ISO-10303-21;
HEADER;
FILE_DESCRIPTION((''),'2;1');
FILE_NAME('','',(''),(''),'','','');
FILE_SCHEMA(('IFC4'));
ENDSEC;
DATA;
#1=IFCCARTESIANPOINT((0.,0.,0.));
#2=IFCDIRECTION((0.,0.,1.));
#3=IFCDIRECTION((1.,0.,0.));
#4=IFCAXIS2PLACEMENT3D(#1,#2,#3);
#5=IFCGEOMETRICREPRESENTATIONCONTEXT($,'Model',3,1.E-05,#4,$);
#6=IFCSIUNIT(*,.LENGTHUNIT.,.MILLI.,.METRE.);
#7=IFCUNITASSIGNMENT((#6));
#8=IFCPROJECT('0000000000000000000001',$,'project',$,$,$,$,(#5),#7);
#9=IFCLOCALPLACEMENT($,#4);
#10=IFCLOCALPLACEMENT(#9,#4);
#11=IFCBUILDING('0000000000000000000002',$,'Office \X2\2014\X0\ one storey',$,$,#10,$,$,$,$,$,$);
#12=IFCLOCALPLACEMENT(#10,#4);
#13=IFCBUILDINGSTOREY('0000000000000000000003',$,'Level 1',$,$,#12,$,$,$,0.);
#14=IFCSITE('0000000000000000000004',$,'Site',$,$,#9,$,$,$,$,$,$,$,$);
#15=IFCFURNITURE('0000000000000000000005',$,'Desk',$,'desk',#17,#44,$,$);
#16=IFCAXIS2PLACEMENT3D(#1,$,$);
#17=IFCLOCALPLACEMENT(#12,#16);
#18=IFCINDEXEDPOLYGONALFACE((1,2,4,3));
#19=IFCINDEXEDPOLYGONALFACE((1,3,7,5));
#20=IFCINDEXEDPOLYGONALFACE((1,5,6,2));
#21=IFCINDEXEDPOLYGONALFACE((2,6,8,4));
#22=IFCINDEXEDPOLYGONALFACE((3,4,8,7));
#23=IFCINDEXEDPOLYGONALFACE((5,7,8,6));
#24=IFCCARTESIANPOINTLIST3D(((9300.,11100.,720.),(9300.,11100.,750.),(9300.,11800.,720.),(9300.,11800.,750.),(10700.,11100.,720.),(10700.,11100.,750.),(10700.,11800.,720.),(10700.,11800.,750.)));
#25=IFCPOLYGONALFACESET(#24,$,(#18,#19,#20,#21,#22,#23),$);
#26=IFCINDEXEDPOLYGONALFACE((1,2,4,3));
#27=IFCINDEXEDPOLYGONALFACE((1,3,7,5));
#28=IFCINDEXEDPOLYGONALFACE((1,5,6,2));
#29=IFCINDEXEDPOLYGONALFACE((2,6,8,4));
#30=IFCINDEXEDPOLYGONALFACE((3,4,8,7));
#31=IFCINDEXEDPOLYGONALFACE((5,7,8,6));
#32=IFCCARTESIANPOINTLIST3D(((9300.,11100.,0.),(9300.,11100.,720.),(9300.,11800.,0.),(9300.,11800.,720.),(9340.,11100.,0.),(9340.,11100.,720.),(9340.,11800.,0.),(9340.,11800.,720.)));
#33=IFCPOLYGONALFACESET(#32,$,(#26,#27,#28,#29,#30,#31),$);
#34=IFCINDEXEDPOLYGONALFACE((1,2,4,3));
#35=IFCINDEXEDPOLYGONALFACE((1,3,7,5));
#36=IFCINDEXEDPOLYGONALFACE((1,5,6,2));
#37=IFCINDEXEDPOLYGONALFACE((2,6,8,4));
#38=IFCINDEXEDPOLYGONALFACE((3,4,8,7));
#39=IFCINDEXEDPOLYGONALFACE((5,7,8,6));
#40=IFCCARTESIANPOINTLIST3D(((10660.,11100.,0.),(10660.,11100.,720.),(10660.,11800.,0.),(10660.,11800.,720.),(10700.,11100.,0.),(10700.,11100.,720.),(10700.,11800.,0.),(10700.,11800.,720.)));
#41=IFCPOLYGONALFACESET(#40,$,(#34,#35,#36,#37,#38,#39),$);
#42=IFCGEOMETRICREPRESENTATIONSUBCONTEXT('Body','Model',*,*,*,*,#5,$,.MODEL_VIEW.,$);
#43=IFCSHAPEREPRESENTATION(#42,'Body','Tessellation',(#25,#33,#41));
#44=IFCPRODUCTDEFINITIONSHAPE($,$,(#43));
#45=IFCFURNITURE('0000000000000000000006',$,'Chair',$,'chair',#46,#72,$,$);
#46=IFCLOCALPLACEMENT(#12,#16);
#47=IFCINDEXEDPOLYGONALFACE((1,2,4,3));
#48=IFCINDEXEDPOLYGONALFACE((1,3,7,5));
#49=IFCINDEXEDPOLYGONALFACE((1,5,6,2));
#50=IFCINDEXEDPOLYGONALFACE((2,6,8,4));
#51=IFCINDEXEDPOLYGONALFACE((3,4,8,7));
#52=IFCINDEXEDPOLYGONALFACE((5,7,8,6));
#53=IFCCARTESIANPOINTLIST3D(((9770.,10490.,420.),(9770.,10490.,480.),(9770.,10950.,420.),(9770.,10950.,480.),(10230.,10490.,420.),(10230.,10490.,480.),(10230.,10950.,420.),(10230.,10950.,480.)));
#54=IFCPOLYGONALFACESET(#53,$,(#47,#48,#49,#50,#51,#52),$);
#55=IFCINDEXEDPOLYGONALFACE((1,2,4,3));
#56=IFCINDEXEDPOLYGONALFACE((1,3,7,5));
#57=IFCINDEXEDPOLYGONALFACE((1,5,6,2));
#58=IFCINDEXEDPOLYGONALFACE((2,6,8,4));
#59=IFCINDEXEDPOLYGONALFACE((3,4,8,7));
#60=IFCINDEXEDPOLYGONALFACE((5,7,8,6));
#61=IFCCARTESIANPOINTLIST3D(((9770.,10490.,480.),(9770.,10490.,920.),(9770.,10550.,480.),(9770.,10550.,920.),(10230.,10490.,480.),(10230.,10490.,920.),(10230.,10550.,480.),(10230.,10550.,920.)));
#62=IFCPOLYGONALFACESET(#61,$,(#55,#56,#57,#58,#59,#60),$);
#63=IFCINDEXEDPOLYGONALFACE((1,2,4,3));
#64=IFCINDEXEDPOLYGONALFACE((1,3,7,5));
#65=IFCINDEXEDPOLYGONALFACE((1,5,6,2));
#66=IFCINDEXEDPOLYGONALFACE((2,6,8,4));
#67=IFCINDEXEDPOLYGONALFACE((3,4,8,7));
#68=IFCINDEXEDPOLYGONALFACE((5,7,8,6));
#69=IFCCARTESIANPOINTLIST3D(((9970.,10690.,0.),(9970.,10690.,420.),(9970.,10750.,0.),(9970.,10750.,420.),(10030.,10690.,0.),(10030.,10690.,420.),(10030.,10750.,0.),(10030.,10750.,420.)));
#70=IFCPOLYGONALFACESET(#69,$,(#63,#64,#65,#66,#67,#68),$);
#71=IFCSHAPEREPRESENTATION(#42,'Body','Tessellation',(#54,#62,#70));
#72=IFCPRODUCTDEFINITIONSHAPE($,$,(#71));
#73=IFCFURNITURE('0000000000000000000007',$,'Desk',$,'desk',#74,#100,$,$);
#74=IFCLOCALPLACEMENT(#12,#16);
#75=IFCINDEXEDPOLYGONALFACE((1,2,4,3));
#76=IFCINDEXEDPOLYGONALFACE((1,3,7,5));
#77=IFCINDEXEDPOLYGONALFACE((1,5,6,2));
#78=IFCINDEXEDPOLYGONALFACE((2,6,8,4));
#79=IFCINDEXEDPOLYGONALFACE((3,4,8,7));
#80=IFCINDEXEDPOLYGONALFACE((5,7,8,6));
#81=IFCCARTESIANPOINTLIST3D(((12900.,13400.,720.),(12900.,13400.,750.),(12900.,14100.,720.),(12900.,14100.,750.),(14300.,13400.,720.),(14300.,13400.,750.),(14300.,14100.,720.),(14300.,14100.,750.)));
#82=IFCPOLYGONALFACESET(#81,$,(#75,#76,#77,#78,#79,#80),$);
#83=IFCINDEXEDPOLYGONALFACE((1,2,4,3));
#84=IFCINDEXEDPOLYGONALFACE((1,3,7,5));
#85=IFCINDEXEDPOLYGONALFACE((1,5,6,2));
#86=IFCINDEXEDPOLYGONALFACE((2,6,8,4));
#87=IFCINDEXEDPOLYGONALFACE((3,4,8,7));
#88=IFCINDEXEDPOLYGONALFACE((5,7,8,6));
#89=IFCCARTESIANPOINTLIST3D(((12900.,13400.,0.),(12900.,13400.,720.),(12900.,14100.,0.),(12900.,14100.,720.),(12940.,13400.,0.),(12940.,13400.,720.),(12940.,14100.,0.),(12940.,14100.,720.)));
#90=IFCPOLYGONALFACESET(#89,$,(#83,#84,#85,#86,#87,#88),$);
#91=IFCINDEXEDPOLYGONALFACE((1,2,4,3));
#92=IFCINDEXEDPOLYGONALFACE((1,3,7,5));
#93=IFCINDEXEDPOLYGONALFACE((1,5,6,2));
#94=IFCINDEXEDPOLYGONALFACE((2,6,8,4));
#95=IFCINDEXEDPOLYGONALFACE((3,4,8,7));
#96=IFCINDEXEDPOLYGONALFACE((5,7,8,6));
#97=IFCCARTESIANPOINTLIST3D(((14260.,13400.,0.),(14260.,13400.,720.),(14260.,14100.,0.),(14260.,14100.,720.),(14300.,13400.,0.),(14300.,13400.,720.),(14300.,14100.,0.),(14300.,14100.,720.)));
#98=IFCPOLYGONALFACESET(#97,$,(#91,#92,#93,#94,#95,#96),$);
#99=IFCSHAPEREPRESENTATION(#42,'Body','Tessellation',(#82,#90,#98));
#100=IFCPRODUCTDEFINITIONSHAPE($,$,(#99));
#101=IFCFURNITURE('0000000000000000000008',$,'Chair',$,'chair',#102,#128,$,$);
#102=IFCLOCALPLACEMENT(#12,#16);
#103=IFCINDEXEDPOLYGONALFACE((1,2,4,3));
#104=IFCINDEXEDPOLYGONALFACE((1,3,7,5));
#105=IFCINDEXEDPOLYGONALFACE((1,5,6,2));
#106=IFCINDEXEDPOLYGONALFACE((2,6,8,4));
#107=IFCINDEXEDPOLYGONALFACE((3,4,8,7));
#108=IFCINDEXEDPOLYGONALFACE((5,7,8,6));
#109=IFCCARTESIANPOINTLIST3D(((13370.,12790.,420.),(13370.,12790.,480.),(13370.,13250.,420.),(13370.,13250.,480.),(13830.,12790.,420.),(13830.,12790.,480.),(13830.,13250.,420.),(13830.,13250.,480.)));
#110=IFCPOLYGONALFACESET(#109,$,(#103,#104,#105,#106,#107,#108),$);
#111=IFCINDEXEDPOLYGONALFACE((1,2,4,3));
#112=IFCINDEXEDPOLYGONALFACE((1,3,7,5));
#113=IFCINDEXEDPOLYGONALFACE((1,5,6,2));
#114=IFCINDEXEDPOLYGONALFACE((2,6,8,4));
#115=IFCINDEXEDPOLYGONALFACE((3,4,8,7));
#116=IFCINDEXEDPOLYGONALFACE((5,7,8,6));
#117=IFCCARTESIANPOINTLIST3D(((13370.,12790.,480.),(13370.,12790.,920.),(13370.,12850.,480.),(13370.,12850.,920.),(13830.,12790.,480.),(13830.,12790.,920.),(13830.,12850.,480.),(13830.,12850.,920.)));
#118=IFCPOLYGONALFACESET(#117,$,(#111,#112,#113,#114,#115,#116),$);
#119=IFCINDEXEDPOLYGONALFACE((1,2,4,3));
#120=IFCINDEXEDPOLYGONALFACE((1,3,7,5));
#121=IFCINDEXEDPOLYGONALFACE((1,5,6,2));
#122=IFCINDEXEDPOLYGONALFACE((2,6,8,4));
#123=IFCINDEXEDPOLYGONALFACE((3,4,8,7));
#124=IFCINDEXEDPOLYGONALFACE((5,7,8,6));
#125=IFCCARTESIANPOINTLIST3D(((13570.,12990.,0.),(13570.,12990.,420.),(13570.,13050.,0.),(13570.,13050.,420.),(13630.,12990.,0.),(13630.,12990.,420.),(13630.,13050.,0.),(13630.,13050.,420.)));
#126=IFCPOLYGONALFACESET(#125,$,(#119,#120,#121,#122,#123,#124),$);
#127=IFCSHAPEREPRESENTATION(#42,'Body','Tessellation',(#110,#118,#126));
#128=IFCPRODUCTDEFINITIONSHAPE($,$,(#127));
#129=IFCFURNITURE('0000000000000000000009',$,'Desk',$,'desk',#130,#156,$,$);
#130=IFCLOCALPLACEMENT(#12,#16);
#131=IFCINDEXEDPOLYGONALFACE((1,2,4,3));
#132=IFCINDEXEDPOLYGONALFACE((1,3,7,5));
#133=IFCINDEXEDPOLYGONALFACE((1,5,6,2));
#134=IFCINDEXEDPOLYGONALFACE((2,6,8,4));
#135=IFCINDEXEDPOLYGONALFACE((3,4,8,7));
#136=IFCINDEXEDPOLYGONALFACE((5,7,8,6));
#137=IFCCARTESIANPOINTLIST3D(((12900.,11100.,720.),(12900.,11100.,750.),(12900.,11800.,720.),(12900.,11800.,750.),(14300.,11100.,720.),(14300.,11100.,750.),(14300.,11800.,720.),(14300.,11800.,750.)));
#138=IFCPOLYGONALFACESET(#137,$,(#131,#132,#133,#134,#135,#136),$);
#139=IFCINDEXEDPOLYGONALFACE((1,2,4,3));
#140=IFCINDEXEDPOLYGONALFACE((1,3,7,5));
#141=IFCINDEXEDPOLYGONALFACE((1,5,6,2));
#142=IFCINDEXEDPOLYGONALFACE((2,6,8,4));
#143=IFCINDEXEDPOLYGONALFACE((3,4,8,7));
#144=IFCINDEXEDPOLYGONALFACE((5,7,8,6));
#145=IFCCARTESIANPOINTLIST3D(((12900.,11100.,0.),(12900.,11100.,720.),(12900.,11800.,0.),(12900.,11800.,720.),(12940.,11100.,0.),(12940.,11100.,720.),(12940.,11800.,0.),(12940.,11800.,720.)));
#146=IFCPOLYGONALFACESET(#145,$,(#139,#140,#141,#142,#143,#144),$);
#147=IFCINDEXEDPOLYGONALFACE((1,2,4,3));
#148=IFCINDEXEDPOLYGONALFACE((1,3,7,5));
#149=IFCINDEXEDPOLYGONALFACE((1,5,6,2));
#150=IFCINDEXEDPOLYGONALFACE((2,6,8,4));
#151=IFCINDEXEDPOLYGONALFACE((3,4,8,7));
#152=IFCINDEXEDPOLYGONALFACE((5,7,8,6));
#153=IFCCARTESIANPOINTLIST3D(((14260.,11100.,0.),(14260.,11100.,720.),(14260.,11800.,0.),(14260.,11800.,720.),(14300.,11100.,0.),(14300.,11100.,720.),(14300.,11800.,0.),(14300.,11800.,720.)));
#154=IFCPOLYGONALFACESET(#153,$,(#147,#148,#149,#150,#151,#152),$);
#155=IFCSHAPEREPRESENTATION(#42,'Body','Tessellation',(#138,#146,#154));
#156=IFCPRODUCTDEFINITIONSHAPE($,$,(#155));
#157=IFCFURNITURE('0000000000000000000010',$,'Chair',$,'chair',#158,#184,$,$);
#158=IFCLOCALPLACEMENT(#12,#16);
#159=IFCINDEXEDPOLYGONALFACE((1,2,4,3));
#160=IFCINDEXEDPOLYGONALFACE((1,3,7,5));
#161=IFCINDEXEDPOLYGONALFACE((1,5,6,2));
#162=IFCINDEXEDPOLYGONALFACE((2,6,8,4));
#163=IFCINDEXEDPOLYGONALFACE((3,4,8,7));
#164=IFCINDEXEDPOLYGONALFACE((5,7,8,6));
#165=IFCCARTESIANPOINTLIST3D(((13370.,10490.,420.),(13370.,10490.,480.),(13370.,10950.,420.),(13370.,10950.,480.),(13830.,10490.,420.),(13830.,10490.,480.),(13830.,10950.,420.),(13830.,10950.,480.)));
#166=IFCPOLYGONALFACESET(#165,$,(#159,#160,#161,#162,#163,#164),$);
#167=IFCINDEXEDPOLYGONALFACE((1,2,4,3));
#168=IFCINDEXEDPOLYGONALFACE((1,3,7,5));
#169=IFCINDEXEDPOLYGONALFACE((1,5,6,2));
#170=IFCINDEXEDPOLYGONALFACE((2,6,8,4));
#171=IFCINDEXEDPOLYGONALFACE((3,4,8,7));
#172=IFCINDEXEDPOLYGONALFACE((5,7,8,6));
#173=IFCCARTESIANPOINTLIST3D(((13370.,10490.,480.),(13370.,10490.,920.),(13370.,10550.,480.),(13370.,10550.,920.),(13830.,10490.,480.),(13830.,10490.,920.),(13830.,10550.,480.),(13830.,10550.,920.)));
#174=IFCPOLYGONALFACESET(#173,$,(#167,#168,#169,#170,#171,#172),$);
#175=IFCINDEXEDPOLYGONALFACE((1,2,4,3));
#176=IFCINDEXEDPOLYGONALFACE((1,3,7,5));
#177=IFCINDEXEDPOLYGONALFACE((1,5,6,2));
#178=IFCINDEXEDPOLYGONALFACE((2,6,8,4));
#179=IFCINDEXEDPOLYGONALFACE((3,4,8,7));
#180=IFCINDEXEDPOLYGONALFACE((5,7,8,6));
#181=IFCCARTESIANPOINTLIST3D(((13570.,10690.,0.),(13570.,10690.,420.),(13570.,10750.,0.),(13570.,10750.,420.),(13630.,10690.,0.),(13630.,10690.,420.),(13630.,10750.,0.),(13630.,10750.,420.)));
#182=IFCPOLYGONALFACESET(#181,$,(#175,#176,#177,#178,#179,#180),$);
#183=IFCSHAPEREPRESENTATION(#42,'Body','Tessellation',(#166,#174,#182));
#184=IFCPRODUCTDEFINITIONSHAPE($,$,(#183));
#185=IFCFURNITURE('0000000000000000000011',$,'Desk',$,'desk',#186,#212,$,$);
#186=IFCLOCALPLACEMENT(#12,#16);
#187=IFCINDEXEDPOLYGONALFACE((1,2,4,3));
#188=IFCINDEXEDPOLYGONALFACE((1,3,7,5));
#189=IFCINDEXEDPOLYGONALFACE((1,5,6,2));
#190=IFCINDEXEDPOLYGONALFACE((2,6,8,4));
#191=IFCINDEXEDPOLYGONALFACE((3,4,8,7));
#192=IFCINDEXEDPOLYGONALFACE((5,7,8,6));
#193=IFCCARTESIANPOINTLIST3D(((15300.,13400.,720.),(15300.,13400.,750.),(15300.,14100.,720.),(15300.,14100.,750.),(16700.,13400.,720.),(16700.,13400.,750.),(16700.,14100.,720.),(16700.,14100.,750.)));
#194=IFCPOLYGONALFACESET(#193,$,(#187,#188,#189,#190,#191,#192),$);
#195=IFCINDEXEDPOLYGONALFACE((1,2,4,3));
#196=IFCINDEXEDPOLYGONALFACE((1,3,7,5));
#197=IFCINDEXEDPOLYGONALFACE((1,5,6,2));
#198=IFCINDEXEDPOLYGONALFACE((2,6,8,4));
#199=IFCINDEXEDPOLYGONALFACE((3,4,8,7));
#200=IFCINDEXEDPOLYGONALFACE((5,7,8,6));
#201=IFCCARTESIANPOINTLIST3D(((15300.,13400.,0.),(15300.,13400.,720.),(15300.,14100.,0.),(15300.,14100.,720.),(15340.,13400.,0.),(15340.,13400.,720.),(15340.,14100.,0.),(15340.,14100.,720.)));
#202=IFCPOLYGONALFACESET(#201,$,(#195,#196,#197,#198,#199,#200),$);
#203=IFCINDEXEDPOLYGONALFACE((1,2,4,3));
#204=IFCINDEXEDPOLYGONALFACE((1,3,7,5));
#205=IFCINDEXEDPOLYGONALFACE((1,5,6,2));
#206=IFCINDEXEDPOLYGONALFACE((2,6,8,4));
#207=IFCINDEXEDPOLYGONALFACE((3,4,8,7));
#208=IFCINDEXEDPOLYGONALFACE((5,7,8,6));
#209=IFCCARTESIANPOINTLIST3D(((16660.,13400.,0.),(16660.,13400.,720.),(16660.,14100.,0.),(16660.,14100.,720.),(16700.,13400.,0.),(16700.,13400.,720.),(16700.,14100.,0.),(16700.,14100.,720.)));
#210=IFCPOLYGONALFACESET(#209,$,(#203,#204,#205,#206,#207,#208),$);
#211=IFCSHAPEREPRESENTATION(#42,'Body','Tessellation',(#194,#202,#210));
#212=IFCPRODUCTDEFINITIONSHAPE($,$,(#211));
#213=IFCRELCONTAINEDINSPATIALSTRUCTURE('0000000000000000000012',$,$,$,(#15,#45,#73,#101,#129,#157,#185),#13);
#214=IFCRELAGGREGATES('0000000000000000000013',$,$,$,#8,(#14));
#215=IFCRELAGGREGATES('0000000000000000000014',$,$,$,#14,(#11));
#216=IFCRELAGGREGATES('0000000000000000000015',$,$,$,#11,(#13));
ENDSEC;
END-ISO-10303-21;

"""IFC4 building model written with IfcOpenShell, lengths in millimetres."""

from ifc_helpers import new_model, si_unit, frame, frame_2d, origin, origin_with_axes, place, context, subcontext, project, spatial, rectangle, extrude, element, save


model = new_model("IFC4")

# Units and contexts
model_context = context("Model", 3, precision=1e-05, world=origin_with_axes())
body_context = subcontext(model_context, "Body", "Model", "MODEL_VIEW")
ifc_project = project(units=[si_unit("LENGTHUNIT", "METRE", prefix="MILLI")], contexts=[model_context])

# Site, building, storey
site_placement = place(None, origin_with_axes())
site = spatial("IfcSite", under=ifc_project, at=site_placement, Name="Site")
building_placement = place(site_placement, origin_with_axes())
building = spatial("IfcBuilding", under=site, at=building_placement, Name="Office — one storey")
storey_placement = place(building_placement, origin_with_axes())
storey = spatial("IfcBuildingStorey", under=building, at=storey_placement, Name="Level 1", Elevation=0.0)

# Furniture
furniture_1_placement = place(storey_placement, frame((9300.0, 11100.0, 0.0), z_axis=(0.0, 0.0, 1.0), x_axis=(1.0, 0.0, 0.0)))
element("IfcFurniture", 1, at=furniture_1_placement, inside=storey, Name="Desk", ObjectType="desk", context=body_context, shape_type="SweptSolid", body=[
    extrude(rectangle(XDim=1400.0, YDim=700.0, at=frame_2d((700.0, 350.0))), frame((0.0, 0.0, 720.0)), (0.0, 0.0, 1.0), 30.0),
    extrude(rectangle(XDim=40.0, YDim=700.0, at=frame_2d((20.0, 350.0))), origin(), (0.0, 0.0, 1.0), 720.0),
    extrude(rectangle(XDim=40.0, YDim=700.0, at=frame_2d((1380.0, 350.0))), origin(), (0.0, 0.0, 1.0), 720.0),
])
furniture_2_placement = place(storey_placement, frame((9770.0, 10490.0, 0.0), z_axis=(0.0, 0.0, 1.0), x_axis=(1.0, 0.0, 0.0)))
element("IfcFurniture", 2, at=furniture_2_placement, inside=storey, Name="Chair", ObjectType="chair", context=body_context, shape_type="SweptSolid", body=[
    extrude(rectangle(XDim=460.0, YDim=460.0, at=frame_2d((230.0, 230.0))), frame((0.0, 0.0, 420.0)), (0.0, 0.0, 1.0), 60.0),
    extrude(rectangle(XDim=460.0, YDim=60.0, at=frame_2d((230.0, 30.0))), frame((0.0, 0.0, 480.0)), (0.0, 0.0, 1.0), 440.0),
    extrude(rectangle(XDim=60.0, YDim=60.0, at=frame_2d((230.0, 230.0))), origin(), (0.0, 0.0, 1.0), 420.0),
])
furniture_3_placement = place(storey_placement, frame((12900.0, 13400.0, 0.0), z_axis=(0.0, 0.0, 1.0), x_axis=(1.0, 0.0, 0.0)))
element("IfcFurniture", 3, at=furniture_3_placement, inside=storey, Name="Desk", ObjectType="desk", context=body_context, shape_type="SweptSolid", body=[
    extrude(rectangle(XDim=1400.0, YDim=700.0, at=frame_2d((700.0, 350.0))), frame((0.0, 0.0, 720.0)), (0.0, 0.0, 1.0), 30.0),
    extrude(rectangle(XDim=40.0, YDim=700.0, at=frame_2d((20.0, 350.0))), origin(), (0.0, 0.0, 1.0), 720.0),
    extrude(rectangle(XDim=40.0, YDim=700.0, at=frame_2d((1380.0, 350.0))), origin(), (0.0, 0.0, 1.0), 720.0),
])
furniture_4_placement = place(storey_placement, frame((13370.0, 12790.0, 0.0), z_axis=(0.0, 0.0, 1.0), x_axis=(1.0, 0.0, 0.0)))
element("IfcFurniture", 4, at=furniture_4_placement, inside=storey, Name="Chair", ObjectType="chair", context=body_context, shape_type="SweptSolid", body=[
    extrude(rectangle(XDim=460.0, YDim=460.0, at=frame_2d((230.0, 230.0))), frame((0.0, 0.0, 420.0)), (0.0, 0.0, 1.0), 60.0),
    extrude(rectangle(XDim=460.0, YDim=60.0, at=frame_2d((230.0, 30.0))), frame((0.0, 0.0, 480.0)), (0.0, 0.0, 1.0), 440.0),
    extrude(rectangle(XDim=60.0, YDim=60.0, at=frame_2d((230.0, 230.0))), origin(), (0.0, 0.0, 1.0), 420.0),
])
furniture_5_placement = place(storey_placement, frame((12900.0, 11100.0, 0.0), z_axis=(0.0, 0.0, 1.0), x_axis=(1.0, 0.0, 0.0)))
element("IfcFurniture", 5, at=furniture_5_placement, inside=storey, Name="Desk", ObjectType="desk", context=body_context, shape_type="SweptSolid", body=[
    extrude(rectangle(XDim=1400.0, YDim=700.0, at=frame_2d((700.0, 350.0))), frame((0.0, 0.0, 720.0)), (0.0, 0.0, 1.0), 30.0),
    extrude(rectangle(XDim=40.0, YDim=700.0, at=frame_2d((20.0, 350.0))), origin(), (0.0, 0.0, 1.0), 720.0),
    extrude(rectangle(XDim=40.0, YDim=700.0, at=frame_2d((1380.0, 350.0))), origin(), (0.0, 0.0, 1.0), 720.0),
])
furniture_6_placement = place(storey_placement, frame((13370.0, 10490.0, 0.0), z_axis=(0.0, 0.0, 1.0), x_axis=(1.0, 0.0, 0.0)))
element("IfcFurniture", 6, at=furniture_6_placement, inside=storey, Name="Chair", ObjectType="chair", context=body_context, shape_type="SweptSolid", body=[
    extrude(rectangle(XDim=460.0, YDim=460.0, at=frame_2d((230.0, 230.0))), frame((0.0, 0.0, 420.0)), (0.0, 0.0, 1.0), 60.0),
    extrude(rectangle(XDim=460.0, YDim=60.0, at=frame_2d((230.0, 30.0))), frame((0.0, 0.0, 480.0)), (0.0, 0.0, 1.0), 440.0),
    extrude(rectangle(XDim=60.0, YDim=60.0, at=frame_2d((230.0, 230.0))), origin(), (0.0, 0.0, 1.0), 420.0),
])
furniture_7_placement = place(storey_placement, frame((15300.0, 13400.0, 0.0), z_axis=(0.0, 0.0, 1.0), x_axis=(1.0, 0.0, 0.0)))
element("IfcFurniture", 7, at=furniture_7_placement, inside=storey, Name="Desk", ObjectType="desk", context=body_context, shape_type="SweptSolid", body=[
    extrude(rectangle(XDim=1400.0, YDim=700.0, at=frame_2d((700.0, 350.0))), frame((0.0, 0.0, 720.0)), (0.0, 0.0, 1.0), 30.0),
    extrude(rectangle(XDim=40.0, YDim=700.0, at=frame_2d((20.0, 350.0))), origin(), (0.0, 0.0, 1.0), 720.0),
    extrude(rectangle(XDim=40.0, YDim=700.0, at=frame_2d((1380.0, 350.0))), origin(), (0.0, 0.0, 1.0), 720.0),
])

save(model, "model.ifc")
